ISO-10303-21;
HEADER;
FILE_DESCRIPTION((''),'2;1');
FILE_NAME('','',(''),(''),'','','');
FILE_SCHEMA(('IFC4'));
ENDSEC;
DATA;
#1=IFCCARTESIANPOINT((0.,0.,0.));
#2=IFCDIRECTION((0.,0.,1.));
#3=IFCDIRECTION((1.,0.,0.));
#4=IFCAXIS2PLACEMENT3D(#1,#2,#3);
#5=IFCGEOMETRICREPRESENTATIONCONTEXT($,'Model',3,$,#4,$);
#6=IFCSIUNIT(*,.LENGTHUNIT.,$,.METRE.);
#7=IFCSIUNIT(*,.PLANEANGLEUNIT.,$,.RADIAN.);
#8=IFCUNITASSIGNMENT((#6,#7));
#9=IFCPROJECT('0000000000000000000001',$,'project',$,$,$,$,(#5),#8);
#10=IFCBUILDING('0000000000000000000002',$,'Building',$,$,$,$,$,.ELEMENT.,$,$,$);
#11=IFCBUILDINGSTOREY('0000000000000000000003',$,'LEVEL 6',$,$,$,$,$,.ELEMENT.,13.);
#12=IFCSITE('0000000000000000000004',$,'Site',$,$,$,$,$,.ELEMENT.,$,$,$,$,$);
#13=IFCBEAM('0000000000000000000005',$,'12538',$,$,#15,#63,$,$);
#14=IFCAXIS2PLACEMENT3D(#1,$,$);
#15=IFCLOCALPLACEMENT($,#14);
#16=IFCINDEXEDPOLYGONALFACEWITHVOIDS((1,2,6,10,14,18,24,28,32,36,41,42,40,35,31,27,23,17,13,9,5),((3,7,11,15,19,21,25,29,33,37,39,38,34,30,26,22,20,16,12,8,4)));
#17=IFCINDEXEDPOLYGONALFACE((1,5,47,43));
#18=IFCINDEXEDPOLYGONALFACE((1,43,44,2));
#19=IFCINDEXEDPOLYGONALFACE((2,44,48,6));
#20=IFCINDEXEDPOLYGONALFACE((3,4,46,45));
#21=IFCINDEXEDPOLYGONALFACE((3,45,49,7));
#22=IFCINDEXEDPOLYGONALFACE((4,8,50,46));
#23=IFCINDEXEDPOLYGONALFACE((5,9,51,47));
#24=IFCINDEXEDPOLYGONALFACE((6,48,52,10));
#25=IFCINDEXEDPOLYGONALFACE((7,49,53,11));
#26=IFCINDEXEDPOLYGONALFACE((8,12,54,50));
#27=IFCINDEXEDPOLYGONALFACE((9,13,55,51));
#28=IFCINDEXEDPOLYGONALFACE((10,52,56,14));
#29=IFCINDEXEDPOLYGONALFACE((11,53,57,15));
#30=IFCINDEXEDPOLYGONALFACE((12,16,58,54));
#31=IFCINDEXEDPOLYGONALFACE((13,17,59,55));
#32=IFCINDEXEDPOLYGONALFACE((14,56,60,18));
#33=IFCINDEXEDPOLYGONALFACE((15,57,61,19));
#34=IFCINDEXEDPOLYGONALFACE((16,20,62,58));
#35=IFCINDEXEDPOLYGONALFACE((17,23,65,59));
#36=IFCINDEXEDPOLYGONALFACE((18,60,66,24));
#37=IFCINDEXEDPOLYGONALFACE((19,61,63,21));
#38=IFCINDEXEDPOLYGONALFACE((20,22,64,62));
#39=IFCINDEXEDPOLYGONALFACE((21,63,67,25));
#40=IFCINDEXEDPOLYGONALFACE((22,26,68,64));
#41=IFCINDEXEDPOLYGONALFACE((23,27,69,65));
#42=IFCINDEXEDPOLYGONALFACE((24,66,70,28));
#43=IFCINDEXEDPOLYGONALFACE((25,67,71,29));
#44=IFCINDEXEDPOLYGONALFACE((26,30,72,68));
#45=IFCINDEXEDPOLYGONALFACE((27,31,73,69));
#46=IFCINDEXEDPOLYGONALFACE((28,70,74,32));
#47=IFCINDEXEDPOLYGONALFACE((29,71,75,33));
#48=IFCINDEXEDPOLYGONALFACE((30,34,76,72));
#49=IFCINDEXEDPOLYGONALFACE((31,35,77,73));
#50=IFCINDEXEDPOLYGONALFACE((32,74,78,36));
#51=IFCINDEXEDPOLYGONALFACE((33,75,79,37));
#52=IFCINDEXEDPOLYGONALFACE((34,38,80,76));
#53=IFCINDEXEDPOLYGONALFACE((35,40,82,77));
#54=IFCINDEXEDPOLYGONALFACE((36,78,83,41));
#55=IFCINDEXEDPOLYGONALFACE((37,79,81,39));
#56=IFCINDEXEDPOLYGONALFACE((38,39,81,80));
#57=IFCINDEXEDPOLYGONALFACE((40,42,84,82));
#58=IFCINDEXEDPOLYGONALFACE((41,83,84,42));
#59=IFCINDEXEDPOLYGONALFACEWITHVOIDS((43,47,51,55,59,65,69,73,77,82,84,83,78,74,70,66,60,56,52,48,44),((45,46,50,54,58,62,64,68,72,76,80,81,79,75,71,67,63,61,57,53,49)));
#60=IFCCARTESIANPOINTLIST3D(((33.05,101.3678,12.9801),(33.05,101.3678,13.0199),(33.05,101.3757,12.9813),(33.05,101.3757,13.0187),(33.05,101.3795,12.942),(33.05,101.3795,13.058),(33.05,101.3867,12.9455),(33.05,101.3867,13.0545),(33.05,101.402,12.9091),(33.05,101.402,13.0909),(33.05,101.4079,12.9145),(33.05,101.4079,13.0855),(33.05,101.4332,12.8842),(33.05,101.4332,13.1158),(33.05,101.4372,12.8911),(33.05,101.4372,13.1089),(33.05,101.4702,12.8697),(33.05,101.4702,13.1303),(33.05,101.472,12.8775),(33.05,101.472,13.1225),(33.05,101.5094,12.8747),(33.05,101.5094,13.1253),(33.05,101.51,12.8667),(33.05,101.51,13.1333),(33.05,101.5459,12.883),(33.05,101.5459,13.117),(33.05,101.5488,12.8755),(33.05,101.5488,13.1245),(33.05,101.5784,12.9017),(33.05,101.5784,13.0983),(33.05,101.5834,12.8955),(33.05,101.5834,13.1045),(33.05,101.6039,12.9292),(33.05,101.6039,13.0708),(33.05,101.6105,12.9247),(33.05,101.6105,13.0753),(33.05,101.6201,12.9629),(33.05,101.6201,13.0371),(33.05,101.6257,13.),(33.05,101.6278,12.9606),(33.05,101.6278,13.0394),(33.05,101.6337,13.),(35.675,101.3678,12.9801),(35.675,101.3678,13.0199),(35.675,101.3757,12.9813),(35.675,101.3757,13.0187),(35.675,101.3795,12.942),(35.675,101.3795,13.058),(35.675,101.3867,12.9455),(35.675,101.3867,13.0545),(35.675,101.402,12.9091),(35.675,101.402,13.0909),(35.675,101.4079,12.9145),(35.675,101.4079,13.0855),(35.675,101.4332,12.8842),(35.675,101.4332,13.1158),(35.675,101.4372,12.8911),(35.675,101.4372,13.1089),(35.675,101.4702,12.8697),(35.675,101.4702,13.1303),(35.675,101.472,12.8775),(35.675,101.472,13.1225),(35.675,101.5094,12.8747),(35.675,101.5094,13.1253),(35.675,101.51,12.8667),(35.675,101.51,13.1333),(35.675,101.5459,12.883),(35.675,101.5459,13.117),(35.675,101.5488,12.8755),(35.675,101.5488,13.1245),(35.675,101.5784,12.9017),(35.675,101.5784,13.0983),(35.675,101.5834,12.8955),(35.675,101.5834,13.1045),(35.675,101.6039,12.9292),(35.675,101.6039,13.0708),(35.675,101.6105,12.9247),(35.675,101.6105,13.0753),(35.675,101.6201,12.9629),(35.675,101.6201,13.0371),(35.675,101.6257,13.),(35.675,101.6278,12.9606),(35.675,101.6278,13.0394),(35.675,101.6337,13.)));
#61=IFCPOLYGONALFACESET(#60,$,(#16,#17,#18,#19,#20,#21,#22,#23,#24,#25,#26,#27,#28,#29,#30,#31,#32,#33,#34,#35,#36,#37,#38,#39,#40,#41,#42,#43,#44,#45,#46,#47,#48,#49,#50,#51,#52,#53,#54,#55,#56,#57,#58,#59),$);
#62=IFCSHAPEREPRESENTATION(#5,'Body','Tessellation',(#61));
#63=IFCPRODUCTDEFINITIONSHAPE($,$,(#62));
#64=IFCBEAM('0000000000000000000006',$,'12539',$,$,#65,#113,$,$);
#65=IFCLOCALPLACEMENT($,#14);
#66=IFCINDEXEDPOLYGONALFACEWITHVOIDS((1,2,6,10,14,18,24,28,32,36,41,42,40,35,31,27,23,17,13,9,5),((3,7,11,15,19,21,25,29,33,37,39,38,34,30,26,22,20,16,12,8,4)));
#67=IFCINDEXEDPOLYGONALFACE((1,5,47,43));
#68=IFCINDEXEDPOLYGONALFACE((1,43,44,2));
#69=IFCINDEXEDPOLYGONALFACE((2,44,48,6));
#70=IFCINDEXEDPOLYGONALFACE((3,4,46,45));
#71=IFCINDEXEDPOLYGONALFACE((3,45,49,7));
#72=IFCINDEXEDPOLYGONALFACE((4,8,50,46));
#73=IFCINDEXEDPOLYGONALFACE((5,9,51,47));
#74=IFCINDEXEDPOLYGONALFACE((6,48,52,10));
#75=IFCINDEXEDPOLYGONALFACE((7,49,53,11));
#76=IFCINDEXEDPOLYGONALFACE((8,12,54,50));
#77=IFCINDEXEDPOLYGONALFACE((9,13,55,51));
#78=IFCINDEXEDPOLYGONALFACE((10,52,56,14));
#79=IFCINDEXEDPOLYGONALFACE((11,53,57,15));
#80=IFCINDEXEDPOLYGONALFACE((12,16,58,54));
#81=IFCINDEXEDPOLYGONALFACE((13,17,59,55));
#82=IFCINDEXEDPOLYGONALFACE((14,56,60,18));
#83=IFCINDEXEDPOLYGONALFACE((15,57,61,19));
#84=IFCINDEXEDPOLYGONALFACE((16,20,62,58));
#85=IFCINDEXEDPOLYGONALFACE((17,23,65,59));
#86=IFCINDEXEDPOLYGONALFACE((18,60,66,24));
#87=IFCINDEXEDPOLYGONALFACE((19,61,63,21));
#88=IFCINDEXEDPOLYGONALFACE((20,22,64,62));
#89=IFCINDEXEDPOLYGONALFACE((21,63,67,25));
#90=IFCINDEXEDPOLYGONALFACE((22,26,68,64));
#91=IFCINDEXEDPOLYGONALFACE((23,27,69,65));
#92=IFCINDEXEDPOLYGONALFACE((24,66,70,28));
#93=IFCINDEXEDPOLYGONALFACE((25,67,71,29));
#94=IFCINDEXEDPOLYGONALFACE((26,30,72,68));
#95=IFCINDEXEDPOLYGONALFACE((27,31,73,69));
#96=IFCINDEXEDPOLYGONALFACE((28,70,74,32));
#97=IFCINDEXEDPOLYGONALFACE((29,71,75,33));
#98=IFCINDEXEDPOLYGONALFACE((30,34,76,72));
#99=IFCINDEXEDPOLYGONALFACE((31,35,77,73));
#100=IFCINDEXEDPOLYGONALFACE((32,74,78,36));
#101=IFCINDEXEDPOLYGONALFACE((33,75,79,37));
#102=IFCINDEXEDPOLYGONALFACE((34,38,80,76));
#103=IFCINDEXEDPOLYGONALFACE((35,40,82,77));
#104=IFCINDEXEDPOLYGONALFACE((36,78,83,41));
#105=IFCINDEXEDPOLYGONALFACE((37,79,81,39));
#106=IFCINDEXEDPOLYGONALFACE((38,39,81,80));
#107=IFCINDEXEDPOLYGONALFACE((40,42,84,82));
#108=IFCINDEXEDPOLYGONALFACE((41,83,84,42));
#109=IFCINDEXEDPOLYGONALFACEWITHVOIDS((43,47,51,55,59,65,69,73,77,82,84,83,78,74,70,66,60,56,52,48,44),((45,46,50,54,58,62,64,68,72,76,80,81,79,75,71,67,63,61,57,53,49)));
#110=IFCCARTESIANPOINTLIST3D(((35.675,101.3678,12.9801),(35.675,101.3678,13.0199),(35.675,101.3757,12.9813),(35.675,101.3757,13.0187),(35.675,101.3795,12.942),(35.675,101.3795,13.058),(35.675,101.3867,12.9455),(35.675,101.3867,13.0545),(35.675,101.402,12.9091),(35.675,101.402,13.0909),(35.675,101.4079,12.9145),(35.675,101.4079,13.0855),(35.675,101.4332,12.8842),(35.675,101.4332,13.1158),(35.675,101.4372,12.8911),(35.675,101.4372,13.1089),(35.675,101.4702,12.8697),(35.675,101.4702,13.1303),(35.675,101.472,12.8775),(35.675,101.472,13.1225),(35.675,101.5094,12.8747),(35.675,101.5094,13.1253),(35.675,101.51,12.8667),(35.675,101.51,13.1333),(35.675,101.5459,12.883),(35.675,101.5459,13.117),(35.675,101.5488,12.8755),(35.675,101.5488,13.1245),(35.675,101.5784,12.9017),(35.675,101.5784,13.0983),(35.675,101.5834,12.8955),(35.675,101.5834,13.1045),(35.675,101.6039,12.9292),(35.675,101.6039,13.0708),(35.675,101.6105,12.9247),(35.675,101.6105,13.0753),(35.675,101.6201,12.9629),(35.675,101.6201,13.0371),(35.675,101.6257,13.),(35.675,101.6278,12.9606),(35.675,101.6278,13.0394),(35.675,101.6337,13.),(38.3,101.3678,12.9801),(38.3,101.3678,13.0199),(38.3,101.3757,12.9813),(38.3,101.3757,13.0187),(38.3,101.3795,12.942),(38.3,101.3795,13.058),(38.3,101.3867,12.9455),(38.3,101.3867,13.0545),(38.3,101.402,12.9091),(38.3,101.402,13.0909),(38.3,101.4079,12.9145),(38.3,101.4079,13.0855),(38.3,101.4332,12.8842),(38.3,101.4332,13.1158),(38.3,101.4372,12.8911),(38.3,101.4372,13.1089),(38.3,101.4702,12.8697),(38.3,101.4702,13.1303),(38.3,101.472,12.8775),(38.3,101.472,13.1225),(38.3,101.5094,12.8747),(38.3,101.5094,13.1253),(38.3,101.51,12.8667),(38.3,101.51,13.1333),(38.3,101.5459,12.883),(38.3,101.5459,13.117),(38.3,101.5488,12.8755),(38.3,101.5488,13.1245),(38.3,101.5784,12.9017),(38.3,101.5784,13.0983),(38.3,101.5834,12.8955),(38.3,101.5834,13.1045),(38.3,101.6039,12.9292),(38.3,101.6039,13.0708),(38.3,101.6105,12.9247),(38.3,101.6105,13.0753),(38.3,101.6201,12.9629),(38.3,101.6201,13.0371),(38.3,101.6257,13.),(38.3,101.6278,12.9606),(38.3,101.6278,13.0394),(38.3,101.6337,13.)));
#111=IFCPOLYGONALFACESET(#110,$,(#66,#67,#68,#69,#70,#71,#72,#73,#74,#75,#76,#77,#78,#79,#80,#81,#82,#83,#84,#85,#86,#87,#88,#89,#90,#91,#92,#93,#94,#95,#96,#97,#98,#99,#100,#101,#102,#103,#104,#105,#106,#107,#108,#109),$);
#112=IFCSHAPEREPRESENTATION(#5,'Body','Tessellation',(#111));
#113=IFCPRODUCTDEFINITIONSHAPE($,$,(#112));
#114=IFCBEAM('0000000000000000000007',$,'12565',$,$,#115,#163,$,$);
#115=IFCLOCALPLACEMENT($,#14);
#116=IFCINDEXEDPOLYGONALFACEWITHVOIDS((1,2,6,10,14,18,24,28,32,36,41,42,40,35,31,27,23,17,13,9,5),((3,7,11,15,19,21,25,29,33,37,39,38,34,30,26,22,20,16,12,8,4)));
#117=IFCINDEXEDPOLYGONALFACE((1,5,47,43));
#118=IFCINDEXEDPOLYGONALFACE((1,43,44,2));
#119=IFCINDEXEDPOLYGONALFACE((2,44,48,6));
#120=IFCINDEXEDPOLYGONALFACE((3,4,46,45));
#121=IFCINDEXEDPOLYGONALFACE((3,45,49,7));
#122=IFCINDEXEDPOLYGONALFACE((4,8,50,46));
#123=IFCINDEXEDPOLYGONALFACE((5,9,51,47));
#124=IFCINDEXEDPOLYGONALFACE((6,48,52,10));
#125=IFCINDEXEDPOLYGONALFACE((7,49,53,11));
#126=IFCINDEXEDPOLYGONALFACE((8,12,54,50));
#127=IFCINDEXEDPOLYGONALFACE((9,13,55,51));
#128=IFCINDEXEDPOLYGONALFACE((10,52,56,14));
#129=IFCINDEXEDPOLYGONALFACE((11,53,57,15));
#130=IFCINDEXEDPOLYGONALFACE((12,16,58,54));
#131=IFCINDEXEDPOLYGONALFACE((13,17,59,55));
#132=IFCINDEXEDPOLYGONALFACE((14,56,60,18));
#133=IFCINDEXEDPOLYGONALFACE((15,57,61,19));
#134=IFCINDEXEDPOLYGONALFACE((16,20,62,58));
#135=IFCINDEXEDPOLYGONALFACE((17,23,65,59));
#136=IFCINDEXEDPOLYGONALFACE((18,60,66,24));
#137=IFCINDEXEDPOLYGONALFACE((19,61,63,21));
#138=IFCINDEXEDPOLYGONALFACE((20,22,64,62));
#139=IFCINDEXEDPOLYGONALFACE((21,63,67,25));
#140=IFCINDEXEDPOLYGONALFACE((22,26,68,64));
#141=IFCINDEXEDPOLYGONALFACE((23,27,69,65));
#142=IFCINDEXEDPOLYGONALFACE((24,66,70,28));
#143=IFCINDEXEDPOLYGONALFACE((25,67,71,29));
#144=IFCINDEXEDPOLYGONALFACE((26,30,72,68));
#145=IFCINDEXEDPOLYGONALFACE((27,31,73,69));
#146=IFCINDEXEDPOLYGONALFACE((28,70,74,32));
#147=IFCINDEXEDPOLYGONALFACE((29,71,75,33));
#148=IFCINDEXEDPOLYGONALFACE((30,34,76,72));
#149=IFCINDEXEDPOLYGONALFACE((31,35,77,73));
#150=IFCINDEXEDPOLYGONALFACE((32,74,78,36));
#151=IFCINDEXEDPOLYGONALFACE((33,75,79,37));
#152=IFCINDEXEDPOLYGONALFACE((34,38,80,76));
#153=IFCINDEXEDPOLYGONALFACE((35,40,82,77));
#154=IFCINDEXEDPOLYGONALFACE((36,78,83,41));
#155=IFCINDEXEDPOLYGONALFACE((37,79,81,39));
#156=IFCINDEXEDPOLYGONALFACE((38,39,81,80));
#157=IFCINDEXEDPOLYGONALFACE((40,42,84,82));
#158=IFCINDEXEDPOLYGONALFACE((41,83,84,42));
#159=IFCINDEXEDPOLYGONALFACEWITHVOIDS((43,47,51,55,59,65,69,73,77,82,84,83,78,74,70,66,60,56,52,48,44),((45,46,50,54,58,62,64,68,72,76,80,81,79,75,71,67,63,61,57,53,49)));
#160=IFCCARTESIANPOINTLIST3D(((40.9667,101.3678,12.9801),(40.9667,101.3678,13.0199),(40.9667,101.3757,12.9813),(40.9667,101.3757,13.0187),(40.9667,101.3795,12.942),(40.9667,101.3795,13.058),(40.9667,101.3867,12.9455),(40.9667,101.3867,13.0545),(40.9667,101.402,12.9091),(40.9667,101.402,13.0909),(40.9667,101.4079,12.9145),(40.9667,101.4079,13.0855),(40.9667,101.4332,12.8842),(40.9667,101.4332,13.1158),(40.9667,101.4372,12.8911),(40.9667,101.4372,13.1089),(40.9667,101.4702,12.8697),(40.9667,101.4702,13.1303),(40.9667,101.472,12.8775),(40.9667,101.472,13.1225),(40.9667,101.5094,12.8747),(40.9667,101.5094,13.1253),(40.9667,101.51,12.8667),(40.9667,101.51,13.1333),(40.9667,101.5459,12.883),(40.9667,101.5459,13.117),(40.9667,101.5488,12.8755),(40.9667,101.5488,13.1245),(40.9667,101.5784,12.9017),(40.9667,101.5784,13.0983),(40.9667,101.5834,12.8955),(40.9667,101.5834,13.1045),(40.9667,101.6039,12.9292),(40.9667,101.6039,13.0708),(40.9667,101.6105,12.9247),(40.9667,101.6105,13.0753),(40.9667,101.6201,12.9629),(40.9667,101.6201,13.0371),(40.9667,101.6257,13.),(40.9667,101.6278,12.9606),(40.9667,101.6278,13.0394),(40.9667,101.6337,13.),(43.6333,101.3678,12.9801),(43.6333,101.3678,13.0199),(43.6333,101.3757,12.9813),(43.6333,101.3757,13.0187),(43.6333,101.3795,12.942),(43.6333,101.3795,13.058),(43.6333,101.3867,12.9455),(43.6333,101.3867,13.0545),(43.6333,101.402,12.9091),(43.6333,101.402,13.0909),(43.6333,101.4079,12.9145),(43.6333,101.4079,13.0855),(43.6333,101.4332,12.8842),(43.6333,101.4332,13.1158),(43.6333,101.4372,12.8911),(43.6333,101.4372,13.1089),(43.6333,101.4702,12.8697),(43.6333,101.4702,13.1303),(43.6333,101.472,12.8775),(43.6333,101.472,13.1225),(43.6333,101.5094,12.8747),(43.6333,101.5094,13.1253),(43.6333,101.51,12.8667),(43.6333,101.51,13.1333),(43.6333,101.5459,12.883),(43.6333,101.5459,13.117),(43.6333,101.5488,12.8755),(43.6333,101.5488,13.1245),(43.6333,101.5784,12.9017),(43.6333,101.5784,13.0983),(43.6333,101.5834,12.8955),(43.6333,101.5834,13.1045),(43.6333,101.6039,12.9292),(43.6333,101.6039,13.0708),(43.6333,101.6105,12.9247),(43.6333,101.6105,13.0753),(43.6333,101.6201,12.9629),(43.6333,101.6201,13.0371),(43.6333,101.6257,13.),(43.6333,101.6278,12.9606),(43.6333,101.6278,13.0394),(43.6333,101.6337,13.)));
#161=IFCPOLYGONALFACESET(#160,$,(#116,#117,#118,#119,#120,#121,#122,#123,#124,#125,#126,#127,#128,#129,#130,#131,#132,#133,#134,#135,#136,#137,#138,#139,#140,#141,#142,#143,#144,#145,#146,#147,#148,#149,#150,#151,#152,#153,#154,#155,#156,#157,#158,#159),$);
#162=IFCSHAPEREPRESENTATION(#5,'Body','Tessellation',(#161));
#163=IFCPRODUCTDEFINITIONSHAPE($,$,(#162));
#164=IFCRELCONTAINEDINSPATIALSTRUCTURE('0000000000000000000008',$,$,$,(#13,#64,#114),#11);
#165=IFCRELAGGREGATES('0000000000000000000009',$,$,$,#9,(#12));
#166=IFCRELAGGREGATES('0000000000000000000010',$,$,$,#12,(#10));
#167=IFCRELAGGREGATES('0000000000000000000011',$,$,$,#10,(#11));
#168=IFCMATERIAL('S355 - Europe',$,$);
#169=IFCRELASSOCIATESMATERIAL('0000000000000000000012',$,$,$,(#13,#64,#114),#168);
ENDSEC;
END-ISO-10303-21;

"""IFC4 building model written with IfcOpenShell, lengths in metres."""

from ifc_helpers import new_model, si_unit, frame, origin_with_axes, origin_2d_with_axis, place, context, project, spatial, hollow_circle, extrude, material, material_profile, profile_set, profile_usage, element, save


model = new_model("IFC4")

# Units and contexts
model_context = context("Model", 3, world=origin_with_axes())
ifc_project = project(units=[si_unit("LENGTHUNIT", "METRE"), si_unit("PLANEANGLEUNIT", "RADIAN")], contexts=[model_context])

# Site, building, storey
site = spatial("IfcSite", under=ifc_project, Name="Site", CompositionType="ELEMENT")
building = spatial("IfcBuilding", under=site, Name="Building", CompositionType="ELEMENT")
storey = spatial("IfcBuildingStorey", under=building, Name="LEVEL 6", CompositionType="ELEMENT", Elevation=13.0)

# Shared definitions
ifc_material = material(Name="S355 - Europe")

# Beams
ifc_material_profile_1 = material_profile(ifc_material, hollow_circle(Radius=0.1337, WallThickness=0.008, at=origin_2d_with_axis()))
ifc_profile_set_1 = profile_set([ifc_material_profile_1])
ifc_profile_usage_1 = profile_usage(ifc_profile_set_1, cardinal=10)
beam_1_placement = place(None, frame((33.05, 101.5, 13.0), z_axis=(1.0, 0.0, 0.0), x_axis=(0.0, 1.0, 0.0)))
element("IfcBeam", 1, at=beam_1_placement, inside=storey, material=ifc_profile_usage_1, Name="12538", context=model_context, shape_type="SweptSolid", body=[
    extrude(hollow_circle(Radius=0.1337, WallThickness=0.008, at=origin_2d_with_axis()), origin_with_axes(), (0.0, 0.0, 1.0), 2.625),
])
ifc_material_profile_2 = material_profile(ifc_material, hollow_circle(Radius=0.1337, WallThickness=0.008, at=origin_2d_with_axis()))
ifc_profile_set_2 = profile_set([ifc_material_profile_2])
ifc_profile_usage_2 = profile_usage(ifc_profile_set_2, cardinal=10)
beam_2_placement = place(None, frame((35.675, 101.5, 13.0), z_axis=(1.0, 0.0, 0.0), x_axis=(0.0, 1.0, 0.0)))
element("IfcBeam", 2, at=beam_2_placement, inside=storey, material=ifc_profile_usage_2, Name="12539", context=model_context, shape_type="SweptSolid", body=[
    extrude(hollow_circle(Radius=0.1337, WallThickness=0.008, at=origin_2d_with_axis()), origin_with_axes(), (0.0, 0.0, 1.0), 2.625),
])
ifc_material_profile_3 = material_profile(ifc_material, hollow_circle(Radius=0.1337, WallThickness=0.008, at=origin_2d_with_axis()))
ifc_profile_set_3 = profile_set([ifc_material_profile_3])
ifc_profile_usage_3 = profile_usage(ifc_profile_set_3, cardinal=10)
beam_3_placement = place(None, frame((40.9667, 101.5, 13.0), z_axis=(1.0, 0.0, 0.0), x_axis=(0.0, 1.0, 0.0)))
element("IfcBeam", 3, at=beam_3_placement, inside=storey, material=ifc_profile_usage_3, Name="12565", context=model_context, shape_type="SweptSolid", body=[
    extrude(hollow_circle(Radius=0.1337, WallThickness=0.008, at=origin_2d_with_axis()), origin_with_axes(), (0.0, 0.0, 1.0), 2.6666),
])

save(model, "model.ifc")
